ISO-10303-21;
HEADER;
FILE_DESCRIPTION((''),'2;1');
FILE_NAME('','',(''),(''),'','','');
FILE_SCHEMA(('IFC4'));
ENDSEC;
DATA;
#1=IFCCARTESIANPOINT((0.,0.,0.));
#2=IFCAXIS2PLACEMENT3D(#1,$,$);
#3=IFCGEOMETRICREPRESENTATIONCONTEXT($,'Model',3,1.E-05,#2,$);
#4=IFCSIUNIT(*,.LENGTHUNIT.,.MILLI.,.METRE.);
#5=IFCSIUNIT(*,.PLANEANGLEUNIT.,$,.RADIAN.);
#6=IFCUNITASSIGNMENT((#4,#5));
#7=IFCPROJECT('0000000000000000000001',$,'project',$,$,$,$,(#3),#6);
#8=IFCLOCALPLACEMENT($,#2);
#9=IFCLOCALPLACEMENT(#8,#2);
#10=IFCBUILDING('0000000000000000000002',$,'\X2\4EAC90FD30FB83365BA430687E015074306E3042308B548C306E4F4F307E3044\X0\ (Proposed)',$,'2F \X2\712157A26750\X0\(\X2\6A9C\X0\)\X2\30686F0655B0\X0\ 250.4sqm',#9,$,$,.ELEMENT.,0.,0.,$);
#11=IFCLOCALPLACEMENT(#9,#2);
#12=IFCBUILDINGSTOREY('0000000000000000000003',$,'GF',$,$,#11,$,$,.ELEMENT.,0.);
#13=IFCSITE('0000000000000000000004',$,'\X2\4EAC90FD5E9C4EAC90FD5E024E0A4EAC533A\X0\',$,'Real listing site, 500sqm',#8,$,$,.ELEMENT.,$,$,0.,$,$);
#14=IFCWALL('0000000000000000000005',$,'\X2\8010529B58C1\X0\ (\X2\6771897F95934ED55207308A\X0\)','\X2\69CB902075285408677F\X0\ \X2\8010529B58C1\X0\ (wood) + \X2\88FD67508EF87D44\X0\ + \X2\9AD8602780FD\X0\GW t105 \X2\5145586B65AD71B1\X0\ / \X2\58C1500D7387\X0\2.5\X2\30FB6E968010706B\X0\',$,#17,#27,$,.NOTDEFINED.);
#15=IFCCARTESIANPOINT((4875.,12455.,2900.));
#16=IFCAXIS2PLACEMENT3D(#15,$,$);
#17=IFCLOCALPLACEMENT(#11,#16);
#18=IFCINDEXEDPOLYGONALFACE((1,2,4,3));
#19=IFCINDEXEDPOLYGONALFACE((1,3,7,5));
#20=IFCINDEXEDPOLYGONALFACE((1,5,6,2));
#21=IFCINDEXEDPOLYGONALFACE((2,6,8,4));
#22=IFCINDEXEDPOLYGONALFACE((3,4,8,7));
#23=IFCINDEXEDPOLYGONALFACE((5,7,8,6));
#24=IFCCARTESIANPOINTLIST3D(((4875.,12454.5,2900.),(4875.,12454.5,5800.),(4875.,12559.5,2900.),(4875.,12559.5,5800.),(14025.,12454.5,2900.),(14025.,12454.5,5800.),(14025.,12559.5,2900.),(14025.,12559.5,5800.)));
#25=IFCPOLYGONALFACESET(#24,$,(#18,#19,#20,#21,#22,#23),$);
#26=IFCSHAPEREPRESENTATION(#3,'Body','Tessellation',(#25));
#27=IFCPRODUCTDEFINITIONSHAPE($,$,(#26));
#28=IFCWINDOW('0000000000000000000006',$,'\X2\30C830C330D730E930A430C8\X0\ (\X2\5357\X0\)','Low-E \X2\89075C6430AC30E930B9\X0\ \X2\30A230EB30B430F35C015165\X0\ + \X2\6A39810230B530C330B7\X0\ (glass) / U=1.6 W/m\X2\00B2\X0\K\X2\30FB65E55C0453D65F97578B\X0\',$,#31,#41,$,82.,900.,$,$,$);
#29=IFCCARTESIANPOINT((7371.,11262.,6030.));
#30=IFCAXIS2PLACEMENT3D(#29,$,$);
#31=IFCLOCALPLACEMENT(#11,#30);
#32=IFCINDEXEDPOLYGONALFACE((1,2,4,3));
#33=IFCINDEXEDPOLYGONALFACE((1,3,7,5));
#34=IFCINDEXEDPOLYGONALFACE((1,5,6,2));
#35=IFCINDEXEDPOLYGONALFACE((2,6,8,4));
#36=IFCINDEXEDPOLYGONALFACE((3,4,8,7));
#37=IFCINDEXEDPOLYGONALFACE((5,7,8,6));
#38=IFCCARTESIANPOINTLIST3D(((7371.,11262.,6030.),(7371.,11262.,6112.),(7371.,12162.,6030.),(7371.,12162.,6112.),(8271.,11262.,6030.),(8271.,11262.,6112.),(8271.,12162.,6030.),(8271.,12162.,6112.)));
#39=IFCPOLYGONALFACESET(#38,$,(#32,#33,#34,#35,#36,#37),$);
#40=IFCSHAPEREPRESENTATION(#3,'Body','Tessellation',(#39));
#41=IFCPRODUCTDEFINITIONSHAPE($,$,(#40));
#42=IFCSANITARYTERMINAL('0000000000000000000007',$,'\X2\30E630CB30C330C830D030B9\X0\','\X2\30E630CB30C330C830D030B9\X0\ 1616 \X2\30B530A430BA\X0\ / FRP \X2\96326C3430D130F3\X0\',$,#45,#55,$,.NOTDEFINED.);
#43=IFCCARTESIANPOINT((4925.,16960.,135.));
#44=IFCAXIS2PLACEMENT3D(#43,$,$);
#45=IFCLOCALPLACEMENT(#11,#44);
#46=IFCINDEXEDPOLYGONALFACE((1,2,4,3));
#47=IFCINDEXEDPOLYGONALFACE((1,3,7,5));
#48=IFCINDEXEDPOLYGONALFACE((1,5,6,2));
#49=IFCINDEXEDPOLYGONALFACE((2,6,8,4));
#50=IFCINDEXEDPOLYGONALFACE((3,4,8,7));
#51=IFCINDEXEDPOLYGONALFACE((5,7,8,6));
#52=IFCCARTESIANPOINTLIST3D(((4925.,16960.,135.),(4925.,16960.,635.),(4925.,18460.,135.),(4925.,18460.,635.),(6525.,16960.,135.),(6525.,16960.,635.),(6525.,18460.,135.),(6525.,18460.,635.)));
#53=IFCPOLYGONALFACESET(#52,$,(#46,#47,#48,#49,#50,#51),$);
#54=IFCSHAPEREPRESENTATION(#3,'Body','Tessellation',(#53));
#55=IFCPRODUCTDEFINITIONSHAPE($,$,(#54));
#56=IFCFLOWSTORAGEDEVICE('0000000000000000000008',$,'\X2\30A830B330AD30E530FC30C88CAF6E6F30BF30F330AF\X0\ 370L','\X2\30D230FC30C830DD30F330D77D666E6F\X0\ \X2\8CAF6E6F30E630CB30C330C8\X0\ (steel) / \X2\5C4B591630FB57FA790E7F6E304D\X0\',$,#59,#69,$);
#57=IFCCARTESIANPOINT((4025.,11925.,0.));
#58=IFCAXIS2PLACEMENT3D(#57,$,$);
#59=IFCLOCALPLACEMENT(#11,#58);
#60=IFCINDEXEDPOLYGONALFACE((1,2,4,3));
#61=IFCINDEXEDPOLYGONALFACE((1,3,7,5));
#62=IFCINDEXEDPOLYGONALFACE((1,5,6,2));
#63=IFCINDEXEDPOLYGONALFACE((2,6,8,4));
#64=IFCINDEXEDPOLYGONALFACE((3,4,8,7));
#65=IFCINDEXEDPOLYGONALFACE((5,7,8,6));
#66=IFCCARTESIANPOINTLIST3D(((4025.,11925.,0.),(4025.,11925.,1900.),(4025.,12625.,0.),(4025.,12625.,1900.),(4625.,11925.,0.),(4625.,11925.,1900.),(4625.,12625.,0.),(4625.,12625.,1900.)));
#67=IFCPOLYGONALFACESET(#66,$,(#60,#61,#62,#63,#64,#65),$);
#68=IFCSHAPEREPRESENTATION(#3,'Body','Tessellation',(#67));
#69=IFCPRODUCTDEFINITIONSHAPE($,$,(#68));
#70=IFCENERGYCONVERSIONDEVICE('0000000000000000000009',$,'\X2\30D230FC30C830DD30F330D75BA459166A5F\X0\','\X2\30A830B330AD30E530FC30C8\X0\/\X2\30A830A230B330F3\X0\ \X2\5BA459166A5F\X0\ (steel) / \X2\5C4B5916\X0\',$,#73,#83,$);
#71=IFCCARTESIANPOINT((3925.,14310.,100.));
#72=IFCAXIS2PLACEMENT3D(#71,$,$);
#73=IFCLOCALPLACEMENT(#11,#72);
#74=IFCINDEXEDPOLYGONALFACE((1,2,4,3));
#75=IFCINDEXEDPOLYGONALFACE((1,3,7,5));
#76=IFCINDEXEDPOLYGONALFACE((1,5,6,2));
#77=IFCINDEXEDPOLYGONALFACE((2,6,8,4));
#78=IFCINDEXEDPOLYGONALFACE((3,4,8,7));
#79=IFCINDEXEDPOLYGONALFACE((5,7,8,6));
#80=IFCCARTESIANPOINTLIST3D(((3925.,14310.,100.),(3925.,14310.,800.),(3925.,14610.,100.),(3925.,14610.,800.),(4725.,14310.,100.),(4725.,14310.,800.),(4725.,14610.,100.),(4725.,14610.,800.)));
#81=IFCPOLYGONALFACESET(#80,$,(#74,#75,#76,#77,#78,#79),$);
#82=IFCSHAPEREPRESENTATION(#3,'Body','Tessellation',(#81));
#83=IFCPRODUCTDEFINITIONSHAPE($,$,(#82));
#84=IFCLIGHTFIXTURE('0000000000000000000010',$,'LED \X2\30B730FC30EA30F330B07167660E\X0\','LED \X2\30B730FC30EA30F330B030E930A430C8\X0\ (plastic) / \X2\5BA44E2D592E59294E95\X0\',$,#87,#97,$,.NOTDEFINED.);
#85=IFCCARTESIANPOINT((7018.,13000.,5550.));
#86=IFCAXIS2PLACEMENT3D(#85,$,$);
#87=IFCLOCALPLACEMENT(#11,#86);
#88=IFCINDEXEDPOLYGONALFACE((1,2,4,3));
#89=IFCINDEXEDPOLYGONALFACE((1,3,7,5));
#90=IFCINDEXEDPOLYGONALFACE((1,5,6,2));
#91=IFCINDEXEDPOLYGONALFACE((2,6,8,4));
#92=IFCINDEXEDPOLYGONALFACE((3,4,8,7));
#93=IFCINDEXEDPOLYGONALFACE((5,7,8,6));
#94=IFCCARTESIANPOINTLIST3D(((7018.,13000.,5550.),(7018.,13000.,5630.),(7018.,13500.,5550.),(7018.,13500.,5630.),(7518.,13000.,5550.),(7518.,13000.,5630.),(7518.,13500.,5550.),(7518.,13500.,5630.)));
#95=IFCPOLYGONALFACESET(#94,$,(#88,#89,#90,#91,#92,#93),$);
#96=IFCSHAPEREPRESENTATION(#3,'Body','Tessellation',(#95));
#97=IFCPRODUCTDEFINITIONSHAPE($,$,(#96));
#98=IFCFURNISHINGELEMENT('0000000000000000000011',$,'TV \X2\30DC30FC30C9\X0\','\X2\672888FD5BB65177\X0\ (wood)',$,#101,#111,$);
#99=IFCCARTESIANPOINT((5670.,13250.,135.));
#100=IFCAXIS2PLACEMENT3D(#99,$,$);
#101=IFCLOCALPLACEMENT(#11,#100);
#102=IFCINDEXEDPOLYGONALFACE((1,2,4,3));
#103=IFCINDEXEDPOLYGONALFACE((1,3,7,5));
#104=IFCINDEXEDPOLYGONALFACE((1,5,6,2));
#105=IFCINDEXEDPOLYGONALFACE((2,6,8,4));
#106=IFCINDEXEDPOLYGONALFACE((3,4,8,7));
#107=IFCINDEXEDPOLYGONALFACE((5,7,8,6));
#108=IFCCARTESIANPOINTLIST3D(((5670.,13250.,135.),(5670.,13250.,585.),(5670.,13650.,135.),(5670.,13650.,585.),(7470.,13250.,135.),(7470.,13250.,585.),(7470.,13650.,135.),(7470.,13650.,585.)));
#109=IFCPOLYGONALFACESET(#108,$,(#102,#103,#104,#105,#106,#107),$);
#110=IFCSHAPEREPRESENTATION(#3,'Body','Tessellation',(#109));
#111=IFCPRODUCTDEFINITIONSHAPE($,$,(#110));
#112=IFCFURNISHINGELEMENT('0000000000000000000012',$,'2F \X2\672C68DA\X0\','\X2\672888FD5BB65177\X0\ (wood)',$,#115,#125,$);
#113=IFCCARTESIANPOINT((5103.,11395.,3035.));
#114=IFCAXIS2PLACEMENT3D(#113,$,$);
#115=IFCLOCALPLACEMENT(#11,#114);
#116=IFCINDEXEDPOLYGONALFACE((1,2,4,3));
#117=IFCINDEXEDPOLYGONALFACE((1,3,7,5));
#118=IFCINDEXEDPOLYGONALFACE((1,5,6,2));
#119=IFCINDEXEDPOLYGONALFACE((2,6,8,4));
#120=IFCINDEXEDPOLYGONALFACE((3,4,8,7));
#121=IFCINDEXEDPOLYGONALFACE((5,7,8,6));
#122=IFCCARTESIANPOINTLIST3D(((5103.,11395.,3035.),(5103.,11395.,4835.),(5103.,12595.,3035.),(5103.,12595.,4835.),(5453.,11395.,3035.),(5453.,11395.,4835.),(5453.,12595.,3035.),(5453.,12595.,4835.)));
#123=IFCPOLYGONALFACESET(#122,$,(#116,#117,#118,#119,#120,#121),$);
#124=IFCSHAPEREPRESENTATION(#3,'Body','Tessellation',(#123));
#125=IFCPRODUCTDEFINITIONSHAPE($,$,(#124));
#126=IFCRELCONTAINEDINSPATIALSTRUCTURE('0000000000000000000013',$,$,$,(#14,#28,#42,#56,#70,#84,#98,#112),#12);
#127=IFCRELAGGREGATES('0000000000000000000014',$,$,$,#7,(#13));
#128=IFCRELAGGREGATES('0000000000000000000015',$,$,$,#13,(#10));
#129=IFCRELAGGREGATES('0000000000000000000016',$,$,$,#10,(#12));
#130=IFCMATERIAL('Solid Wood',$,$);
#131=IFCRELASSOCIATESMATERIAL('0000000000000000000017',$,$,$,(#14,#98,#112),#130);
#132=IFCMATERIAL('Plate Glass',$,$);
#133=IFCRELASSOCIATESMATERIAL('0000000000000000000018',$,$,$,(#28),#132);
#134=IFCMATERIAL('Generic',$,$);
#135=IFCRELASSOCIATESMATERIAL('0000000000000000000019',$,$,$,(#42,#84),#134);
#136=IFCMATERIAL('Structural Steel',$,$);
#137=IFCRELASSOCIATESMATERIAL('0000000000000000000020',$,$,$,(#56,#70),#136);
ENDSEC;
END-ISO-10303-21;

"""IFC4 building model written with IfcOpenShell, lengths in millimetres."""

from ifc_helpers import new_model, si_unit, frame, frame_2d, origin, place, context, project, spatial, rectangle, extrude, material, element, save


model = new_model("IFC4")

# Units and contexts
model_context = context("Model", 3, precision=1e-05, world=origin())
ifc_project = project(units=[si_unit("LENGTHUNIT", "METRE", prefix="MILLI"), si_unit("PLANEANGLEUNIT", "RADIAN")], contexts=[model_context])

# Site, building, storey
site_placement = place(None, origin())
site = spatial("IfcSite", under=ifc_project, at=site_placement, Name="京都府京都市上京区", ObjectType="Real listing site, 500sqm", CompositionType="ELEMENT", RefElevation=0.0)
building_placement = place(site_placement, origin())
building = spatial("IfcBuilding", under=site, at=building_placement, Name="京都・茶室と縁側のある和の住まい (Proposed)", ObjectType="2F 無垢材(檜)と漆喰 250.4sqm", CompositionType="ELEMENT", ElevationOfRefHeight=0.0, ElevationOfTerrain=0.0)
storey_placement = place(building_placement, origin())
storey = spatial("IfcBuildingStorey", under=building, at=storey_placement, Name="GF", CompositionType="ELEMENT", Elevation=0.0)

# Shared definitions
ifc_material_1 = material(Name="Solid Wood")

# Wall
wall_1_placement = place(storey_placement, frame((4875.0, 12455.0, 2900.0)))
element("IfcWall", 1, at=wall_1_placement, inside=storey, material=ifc_material_1, Name="耐力壁 (東西間仕切り)", Description="構造用合板 耐力壁 (wood) + 製材軸組 + 高性能GW t105 充填断熱 / 壁倍率2.5・準耐火", PredefinedType="NOTDEFINED", context=model_context, shape_type="SweptSolid", body=[
    extrude(rectangle(XDim=9150.0, YDim=105.0, at=frame_2d((4575.0, 52.0))), frame((4875.0, 12455.0, 2900.0)), (0.0, 0.0, 1.0), 2900.0),
])

# Window
ifc_material_2 = material(Name="Plate Glass")
window_placement = place(storey_placement, frame((7371.0, 11262.0, 6030.0)))
element("IfcWindow", 2, at=window_placement, inside=storey, material=ifc_material_2, Name="トップライト (南)", Description="Low-E 複層ガラス アルゴン封入 + 樹脂サッシ (glass) / U=1.6 W/m²K・日射取得型", OverallHeight=82.0, OverallWidth=900.0, context=model_context, shape_type="SweptSolid", body=[
    extrude(rectangle(XDim=900.0, YDim=900.0, at=frame_2d((450.0, 450.0))), frame((7371.0, 11262.0, 6030.0)), (0.0, 0.0, 1.0), 82.0),
])

# Sanitary terminal
ifc_material_3 = material(Name="Generic")
sanitary_terminal_placement = place(storey_placement, frame((4925.0, 16960.0, 135.0)))
element("IfcSanitaryTerminal", 3, at=sanitary_terminal_placement, inside=storey, material=ifc_material_3, Name="ユニットバス", Description="ユニットバス 1616 サイズ / FRP 防水パン", PredefinedType="NOTDEFINED", context=model_context, shape_type="SweptSolid", body=[
    extrude(rectangle(XDim=1600.0, YDim=1500.0, at=frame_2d((800.0, 750.0))), frame((4925.0, 16960.0, 135.0)), (0.0, 0.0, 1.0), 500.0),
])

# Flow storage device
ifc_material_4 = material(Name="Structural Steel")
flow_storage_device_placement = place(storey_placement, frame((4025.0, 11925.0, 0.0)))
element("IfcFlowStorageDevice", 4, at=flow_storage_device_placement, inside=storey, material=ifc_material_4, Name="エコキュート貯湯タンク 370L", Description="ヒートポンプ給湯 貯湯ユニット (steel) / 屋外・基礎置き", context=model_context, shape_type="SweptSolid", body=[
    extrude(rectangle(XDim=600.0, YDim=700.0, at=frame_2d((300.0, 350.0))), frame((4025.0, 11925.0, 0.0)), (0.0, 0.0, 1.0), 1900.0),
])

# Energy conversion device
energy_conversion_device_placement = place(storey_placement, frame((3925.0, 14310.0, 100.0)))
element("IfcEnergyConversionDevice", 5, at=energy_conversion_device_placement, inside=storey, material=ifc_material_4, Name="ヒートポンプ室外機", Description="エコキュート/エアコン 室外機 (steel) / 屋外", context=model_context, shape_type="SweptSolid", body=[
    extrude(rectangle(XDim=800.0, YDim=300.0, at=frame_2d((400.0, 150.0))), frame((3925.0, 14310.0, 100.0)), (0.0, 0.0, 1.0), 700.0),
])

# Light fixture
light_fixture_placement = place(storey_placement, frame((7018.0, 13000.0, 5550.0)))
element("IfcLightFixture", 6, at=light_fixture_placement, inside=storey, material=ifc_material_3, Name="LED シーリング照明", Description="LED シーリングライト (plastic) / 室中央天井", PredefinedType="NOTDEFINED", context=model_context, shape_type="SweptSolid", body=[
    extrude(rectangle(XDim=500.0, YDim=500.0, at=frame_2d((250.0, 250.0))), frame((7018.0, 13000.0, 5550.0)), (0.0, 0.0, 1.0), 80.0),
])

# Furnishing elements
furnishing_1_placement = place(storey_placement, frame((5670.0, 13250.0, 135.0)))
element("IfcFurnishingElement", 7, at=furnishing_1_placement, inside=storey, material=ifc_material_1, Name="TV ボード", Description="木製家具 (wood)", context=model_context, shape_type="SweptSolid", body=[
    extrude(rectangle(XDim=1800.0, YDim=400.0, at=frame_2d((900.0, 200.0))), frame((5670.0, 13250.0, 135.0)), (0.0, 0.0, 1.0), 450.0),
])
furnishing_2_placement = place(storey_placement, frame((5103.0, 11395.0, 3035.0)))
element("IfcFurnishingElement", 8, at=furnishing_2_placement, inside=storey, material=ifc_material_1, Name="2F 本棚", Description="木製家具 (wood)", context=model_context, shape_type="SweptSolid", body=[
    extrude(rectangle(XDim=350.0, YDim=1200.0, at=frame_2d((175.0, 600.0))), frame((5103.0, 11395.0, 3035.0)), (0.0, 0.0, 1.0), 1800.0),
])

save(model, "model.ifc")
